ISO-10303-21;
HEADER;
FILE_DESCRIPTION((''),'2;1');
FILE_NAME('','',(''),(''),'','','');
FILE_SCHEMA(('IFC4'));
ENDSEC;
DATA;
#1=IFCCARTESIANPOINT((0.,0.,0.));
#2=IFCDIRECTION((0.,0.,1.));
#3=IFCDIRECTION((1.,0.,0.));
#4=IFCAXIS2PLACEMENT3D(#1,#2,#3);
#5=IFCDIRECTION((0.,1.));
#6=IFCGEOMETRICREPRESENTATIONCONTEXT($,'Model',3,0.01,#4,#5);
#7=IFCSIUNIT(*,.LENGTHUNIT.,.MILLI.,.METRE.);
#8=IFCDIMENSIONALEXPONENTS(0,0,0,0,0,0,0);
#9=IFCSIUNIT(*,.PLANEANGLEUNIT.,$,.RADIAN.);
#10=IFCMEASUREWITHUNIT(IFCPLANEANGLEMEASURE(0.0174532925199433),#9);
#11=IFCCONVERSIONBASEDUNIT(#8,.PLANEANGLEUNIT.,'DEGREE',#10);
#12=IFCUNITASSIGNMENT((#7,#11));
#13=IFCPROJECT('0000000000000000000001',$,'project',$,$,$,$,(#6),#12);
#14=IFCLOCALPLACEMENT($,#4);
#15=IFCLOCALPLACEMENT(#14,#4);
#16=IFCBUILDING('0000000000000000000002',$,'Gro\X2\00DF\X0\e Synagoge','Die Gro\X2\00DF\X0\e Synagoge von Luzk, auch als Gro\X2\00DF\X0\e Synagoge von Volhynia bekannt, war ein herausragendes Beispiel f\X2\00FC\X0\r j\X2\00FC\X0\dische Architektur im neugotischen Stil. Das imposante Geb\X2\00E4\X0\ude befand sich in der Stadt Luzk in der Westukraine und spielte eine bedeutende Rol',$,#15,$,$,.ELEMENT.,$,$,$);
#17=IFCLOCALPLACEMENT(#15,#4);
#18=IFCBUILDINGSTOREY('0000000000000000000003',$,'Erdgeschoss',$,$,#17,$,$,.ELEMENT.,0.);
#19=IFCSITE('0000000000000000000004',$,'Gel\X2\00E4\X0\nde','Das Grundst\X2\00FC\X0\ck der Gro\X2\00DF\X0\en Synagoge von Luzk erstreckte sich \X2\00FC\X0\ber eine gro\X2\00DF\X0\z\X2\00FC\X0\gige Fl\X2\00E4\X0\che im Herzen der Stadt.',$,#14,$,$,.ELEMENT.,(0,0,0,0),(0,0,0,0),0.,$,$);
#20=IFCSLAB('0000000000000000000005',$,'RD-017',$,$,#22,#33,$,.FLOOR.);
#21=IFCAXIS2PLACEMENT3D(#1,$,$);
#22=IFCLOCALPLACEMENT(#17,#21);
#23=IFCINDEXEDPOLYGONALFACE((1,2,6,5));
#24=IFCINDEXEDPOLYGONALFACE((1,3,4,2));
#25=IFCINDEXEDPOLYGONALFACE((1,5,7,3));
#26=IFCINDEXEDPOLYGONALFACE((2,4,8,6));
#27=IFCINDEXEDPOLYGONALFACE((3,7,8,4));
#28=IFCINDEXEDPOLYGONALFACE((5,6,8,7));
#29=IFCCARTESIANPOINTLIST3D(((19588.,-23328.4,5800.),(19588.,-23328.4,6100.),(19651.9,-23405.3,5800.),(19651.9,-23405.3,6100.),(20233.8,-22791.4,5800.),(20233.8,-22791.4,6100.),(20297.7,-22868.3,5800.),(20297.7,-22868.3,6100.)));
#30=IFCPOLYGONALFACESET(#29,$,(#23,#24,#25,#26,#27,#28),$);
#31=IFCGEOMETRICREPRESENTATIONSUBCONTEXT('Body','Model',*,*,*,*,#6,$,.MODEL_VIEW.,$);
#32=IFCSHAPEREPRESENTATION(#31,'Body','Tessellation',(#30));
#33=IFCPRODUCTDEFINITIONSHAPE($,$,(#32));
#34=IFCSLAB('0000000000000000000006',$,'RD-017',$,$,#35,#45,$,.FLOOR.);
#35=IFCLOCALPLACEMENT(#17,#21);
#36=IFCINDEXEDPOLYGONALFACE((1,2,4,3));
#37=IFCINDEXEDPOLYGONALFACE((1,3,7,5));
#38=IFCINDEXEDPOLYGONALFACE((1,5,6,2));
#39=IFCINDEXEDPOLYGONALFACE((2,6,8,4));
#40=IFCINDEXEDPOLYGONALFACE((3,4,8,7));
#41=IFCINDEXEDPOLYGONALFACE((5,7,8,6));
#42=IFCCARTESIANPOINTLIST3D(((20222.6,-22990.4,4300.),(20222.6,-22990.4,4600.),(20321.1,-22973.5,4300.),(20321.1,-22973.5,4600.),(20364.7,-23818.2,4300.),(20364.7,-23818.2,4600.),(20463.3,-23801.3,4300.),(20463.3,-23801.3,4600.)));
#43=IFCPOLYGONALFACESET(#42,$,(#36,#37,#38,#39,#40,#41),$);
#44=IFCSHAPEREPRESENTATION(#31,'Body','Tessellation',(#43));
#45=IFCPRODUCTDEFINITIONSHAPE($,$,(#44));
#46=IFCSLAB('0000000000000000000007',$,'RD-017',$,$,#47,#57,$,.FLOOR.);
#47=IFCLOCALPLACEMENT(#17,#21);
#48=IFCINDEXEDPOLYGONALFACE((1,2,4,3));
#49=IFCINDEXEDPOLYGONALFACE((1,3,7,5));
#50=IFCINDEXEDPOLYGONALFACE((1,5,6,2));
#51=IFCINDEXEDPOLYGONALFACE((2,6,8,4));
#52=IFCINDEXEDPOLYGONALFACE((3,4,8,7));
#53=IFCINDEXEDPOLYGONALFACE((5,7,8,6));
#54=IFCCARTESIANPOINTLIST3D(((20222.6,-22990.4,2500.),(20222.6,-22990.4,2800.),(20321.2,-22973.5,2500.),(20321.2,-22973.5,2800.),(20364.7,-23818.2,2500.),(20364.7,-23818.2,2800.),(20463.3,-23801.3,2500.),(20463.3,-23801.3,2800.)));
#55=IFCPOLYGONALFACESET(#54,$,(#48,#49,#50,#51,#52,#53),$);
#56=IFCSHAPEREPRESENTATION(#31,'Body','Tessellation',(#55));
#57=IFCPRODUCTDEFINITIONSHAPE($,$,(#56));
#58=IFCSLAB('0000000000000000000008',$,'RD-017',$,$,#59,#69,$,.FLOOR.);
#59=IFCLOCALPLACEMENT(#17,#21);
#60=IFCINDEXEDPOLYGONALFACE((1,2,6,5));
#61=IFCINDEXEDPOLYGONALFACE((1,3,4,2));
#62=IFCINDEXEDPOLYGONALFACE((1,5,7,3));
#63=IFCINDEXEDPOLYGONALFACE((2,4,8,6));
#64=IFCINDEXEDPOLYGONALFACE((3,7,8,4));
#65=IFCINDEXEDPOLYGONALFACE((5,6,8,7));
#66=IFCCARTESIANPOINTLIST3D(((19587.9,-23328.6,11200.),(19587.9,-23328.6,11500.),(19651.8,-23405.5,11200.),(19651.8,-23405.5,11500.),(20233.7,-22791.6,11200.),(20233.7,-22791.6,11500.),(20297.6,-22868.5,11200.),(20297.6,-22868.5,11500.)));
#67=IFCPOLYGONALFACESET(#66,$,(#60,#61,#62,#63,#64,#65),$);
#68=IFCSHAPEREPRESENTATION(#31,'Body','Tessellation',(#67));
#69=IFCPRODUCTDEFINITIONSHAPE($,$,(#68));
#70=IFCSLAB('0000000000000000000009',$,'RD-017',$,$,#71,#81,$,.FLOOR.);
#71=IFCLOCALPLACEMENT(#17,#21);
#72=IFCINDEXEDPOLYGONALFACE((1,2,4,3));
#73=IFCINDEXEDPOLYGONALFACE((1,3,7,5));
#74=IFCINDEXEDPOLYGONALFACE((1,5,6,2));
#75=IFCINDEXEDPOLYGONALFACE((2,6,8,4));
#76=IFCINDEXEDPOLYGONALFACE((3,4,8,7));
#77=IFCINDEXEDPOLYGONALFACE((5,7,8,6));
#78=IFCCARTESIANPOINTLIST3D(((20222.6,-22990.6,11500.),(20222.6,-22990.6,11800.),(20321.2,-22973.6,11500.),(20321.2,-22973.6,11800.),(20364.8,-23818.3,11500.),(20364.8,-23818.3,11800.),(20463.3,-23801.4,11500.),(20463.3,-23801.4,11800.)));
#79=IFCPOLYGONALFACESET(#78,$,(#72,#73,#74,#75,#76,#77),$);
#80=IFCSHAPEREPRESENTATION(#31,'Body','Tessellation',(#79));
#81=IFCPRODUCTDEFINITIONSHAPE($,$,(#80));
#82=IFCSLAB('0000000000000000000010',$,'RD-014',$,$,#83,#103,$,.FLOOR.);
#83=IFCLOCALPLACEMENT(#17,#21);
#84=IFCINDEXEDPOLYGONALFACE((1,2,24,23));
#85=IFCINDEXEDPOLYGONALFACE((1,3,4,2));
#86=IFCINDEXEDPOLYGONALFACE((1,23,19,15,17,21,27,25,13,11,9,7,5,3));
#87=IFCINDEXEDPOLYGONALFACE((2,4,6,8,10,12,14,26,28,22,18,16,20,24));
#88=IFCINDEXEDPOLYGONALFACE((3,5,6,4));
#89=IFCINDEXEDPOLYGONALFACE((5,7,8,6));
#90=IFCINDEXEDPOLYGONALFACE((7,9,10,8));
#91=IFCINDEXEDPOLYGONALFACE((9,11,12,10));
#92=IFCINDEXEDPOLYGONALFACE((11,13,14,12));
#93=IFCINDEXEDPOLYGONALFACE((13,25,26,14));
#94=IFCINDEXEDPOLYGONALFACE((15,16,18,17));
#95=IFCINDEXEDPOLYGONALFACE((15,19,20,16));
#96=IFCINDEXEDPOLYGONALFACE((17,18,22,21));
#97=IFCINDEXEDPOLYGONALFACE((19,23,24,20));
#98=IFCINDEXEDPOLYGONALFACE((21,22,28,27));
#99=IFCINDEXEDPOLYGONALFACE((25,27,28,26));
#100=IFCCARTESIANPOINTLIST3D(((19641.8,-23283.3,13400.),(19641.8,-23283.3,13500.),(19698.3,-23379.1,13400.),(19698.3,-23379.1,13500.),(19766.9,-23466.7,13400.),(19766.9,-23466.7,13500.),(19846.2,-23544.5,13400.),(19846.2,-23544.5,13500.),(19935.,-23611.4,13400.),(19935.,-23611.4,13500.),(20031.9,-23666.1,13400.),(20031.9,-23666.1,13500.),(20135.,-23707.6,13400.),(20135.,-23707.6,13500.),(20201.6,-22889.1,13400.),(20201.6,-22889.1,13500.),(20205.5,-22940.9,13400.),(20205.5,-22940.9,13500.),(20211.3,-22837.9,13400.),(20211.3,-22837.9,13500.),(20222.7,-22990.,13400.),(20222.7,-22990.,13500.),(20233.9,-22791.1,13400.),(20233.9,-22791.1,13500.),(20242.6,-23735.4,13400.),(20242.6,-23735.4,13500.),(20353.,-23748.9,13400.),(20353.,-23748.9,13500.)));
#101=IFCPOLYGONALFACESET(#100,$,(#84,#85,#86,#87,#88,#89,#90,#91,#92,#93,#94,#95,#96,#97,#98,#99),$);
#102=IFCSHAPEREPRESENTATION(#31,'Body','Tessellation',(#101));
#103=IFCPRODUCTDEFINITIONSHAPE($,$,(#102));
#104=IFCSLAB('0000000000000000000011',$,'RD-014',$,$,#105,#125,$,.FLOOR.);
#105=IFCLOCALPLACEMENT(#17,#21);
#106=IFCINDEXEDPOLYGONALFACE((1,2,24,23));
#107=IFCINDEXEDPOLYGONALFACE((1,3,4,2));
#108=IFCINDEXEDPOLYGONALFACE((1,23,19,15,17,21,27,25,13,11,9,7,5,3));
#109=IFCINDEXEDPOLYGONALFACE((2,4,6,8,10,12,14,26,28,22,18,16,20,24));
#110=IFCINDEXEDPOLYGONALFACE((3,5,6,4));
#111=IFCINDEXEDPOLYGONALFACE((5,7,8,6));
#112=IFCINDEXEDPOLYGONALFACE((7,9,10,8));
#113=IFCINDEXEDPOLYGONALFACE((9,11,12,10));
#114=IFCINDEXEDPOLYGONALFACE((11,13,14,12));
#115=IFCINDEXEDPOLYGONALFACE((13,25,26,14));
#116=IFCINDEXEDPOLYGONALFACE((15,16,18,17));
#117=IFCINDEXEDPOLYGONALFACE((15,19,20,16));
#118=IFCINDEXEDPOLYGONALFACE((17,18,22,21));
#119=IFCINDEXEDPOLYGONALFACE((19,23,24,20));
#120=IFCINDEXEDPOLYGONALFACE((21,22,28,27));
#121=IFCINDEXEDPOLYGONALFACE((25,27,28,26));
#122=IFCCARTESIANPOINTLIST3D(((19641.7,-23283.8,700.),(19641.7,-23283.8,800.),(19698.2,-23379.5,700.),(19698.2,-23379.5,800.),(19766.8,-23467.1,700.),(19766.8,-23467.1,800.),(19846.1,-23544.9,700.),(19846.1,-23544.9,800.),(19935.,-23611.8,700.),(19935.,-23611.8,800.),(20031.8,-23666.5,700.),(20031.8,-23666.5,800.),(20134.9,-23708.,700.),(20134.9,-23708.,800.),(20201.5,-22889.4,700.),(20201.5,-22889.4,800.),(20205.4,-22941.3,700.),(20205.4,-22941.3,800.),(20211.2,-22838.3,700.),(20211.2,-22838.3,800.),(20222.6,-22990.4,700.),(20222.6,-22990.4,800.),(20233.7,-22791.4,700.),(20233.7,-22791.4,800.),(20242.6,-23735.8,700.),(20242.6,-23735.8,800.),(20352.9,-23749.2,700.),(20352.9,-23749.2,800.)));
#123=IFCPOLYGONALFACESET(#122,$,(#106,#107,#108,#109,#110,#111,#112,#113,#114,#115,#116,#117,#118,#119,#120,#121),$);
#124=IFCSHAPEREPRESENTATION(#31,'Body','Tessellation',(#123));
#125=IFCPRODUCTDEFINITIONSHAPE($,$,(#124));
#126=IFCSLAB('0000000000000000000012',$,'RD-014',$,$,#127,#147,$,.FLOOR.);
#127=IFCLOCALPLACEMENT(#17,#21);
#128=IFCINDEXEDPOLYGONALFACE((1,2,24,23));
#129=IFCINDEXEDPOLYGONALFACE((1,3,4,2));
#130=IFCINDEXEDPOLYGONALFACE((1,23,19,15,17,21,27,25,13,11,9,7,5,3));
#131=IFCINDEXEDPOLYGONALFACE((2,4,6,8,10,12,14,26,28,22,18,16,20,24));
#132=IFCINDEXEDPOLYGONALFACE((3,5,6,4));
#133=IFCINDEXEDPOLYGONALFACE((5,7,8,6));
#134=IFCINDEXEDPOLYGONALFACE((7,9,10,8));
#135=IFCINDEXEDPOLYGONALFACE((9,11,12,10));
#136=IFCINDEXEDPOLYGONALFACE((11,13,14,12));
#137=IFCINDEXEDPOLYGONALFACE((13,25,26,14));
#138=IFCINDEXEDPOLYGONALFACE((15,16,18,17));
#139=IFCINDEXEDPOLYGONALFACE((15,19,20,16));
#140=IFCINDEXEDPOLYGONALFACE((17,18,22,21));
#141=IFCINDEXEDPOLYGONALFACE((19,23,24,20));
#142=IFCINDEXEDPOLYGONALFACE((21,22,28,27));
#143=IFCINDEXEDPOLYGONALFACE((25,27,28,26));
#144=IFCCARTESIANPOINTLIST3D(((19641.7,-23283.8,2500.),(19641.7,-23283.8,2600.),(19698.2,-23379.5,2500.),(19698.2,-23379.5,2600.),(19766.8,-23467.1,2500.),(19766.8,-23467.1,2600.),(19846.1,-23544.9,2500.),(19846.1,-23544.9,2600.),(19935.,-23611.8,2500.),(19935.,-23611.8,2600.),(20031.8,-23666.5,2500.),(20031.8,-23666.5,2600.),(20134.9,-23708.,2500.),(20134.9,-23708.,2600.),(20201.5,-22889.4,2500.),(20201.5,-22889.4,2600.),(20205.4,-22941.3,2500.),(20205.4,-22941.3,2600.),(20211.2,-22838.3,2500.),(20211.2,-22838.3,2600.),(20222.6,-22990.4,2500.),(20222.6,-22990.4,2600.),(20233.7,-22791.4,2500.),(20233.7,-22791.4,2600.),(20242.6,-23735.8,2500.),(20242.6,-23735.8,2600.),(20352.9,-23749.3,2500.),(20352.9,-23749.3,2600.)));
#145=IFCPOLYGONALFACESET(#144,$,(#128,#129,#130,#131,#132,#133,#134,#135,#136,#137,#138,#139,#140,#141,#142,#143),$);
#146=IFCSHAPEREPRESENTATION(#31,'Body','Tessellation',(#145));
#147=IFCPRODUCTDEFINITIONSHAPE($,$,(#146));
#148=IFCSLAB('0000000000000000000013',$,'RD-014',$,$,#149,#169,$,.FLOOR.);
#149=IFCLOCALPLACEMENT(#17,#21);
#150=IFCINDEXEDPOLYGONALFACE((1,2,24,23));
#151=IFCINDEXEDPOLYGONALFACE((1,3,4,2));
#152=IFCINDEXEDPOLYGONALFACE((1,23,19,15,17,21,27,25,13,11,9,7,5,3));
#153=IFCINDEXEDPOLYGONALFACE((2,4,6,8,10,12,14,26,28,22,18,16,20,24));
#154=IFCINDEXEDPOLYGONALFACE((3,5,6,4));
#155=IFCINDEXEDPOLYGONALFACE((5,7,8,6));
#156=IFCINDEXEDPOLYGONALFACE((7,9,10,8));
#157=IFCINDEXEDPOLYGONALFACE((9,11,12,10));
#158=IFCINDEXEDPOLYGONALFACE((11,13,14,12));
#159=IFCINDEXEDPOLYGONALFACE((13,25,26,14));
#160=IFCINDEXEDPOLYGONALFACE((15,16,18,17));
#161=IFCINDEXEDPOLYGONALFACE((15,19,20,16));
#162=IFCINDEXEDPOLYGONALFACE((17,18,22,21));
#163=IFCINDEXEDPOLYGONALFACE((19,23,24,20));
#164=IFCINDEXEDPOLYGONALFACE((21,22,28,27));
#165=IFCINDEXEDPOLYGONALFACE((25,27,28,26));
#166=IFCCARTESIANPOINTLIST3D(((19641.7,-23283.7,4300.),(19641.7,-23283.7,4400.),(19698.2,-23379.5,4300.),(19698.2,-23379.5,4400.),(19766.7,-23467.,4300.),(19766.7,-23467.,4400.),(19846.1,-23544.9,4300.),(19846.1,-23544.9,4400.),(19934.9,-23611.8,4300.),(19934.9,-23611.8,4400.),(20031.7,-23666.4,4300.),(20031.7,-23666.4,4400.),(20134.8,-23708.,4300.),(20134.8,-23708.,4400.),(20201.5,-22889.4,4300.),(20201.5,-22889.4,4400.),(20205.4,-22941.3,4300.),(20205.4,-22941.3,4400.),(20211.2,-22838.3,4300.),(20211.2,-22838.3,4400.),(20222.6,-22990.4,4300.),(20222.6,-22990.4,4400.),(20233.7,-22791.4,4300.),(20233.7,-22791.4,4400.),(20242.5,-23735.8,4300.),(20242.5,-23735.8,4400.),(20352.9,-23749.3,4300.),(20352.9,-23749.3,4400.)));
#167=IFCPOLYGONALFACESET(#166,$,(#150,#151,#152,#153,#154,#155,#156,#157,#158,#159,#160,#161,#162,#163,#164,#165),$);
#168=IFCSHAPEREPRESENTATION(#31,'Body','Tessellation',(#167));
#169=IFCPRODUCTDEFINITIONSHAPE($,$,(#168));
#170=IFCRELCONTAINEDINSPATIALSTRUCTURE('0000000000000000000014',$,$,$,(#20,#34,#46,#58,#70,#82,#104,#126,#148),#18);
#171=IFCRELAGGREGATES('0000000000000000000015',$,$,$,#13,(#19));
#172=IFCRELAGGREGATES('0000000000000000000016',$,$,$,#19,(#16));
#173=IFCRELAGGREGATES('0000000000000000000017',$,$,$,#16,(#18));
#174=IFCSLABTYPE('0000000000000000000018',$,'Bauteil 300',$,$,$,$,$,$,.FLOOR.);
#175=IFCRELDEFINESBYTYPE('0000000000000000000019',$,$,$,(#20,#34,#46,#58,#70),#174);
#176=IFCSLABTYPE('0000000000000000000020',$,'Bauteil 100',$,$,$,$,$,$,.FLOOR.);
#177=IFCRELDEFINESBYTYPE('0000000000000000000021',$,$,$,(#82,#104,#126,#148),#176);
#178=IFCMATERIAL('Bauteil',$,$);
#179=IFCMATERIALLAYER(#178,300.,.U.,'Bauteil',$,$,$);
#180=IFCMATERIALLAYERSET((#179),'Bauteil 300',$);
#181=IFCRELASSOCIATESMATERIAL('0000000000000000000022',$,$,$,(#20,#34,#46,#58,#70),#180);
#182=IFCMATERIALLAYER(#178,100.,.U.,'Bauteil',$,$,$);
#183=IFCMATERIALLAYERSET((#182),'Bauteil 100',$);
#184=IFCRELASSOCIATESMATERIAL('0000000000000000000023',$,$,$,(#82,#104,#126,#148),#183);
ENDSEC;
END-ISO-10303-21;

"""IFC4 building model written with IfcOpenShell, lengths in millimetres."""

from ifc_helpers import new_model, entity, si_unit, converted_unit, direction, frame, origin_with_axes, place, context, subcontext, project, spatial, line, arc, indexed_curve, outline, extrude, material, layer, layer_set, layer_usage, type_object, element, save


model = new_model("IFC4")

# Units and contexts
model_context = context("Model", 3, precision=0.01, world=origin_with_axes(), true_north=direction((0.0, 1.0)))
body_context = subcontext(model_context, "Body", "Model", "MODEL_VIEW")
ifc_project = project(units=[si_unit("LENGTHUNIT", "METRE", prefix="MILLI"), converted_unit("PLANEANGLEUNIT", "DEGREE", entity("IfcPlaneAngleMeasure", 0.0174532925199433), si_unit("PLANEANGLEUNIT", "RADIAN"), dimensions=[0, 0, 0, 0, 0, 0, 0])], contexts=[model_context])

# Site, building, storey
site_placement = place(None, origin_with_axes())
site = spatial("IfcSite", under=ifc_project, at=site_placement, Name="Gelände", Description="Das Grundstück der Großen Synagoge von Luzk erstreckte sich über eine großzügige Fläche im Herzen der Stadt.", CompositionType="ELEMENT", RefLatitude=(0, 0, 0, 0), RefLongitude=(0, 0, 0, 0), RefElevation=0.0)
building_placement = place(site_placement, origin_with_axes())
building = spatial("IfcBuilding", under=site, at=building_placement, Name="Große Synagoge", Description="Die Große Synagoge von Luzk, auch als Große Synagoge von Volhynia bekannt, war ein herausragendes Beispiel für jüdische Architektur im neugotischen Stil. Das imposante Gebäude befand sich in der Stadt Luzk in der Westukraine und spielte eine bedeutende Rol", CompositionType="ELEMENT")
storey_placement = place(building_placement, origin_with_axes())
storey = spatial("IfcBuildingStorey", under=building, at=storey_placement, Name="Erdgeschoss", CompositionType="ELEMENT", Elevation=0.0)

# Slabs
ifc_material_1 = material(Name="Bauteil")
ifc_layer_1 = layer(ifc_material_1, 300.0, ventilated="UNKNOWN", Name="Bauteil")
ifc_layer_set_1 = layer_set([ifc_layer_1], Name="Bauteil 300")
ifc_layer_usage_1 = layer_usage(ifc_layer_set_1, "AXIS3", "NEGATIVE", 300.0)
slab_type_1 = type_object("IfcSlabType", Name="Bauteil 300", PredefinedType="FLOOR")
slab_1_placement = place(storey_placement, frame((20297.7, -22868.3, 6100.0), z_axis=(0.0, 0.0, 1.0), x_axis=(1.0, 0.0, 0.0)))
element("IfcSlab", 1, at=slab_1_placement, inside=storey, type_object=slab_type_1, material=ifc_layer_usage_1, Name="RD-017", PredefinedType="FLOOR", context=body_context, shape_type="SweptSolid", body=[
    extrude(outline(indexed_curve([(0.0, 0.0), (-63.9, 76.9), (-709.7, -460.1), (-645.8, -537.0)], segments=[line(1, 2, 3, 4, 1)])), frame((0.0, 0.0, -300.0), z_axis=(0.0, 0.0, 1.0), x_axis=(1.0, 0.0, 0.0)), (0.0, 0.0, 1.0), 300.0),
])
ifc_layer_usage_2 = layer_usage(ifc_layer_set_1, "AXIS3", "NEGATIVE", 300.0)
slab_2_placement = place(storey_placement, frame((20321.1, -22973.5, 4600.0), z_axis=(0.0, 0.0, 1.0), x_axis=(1.0, 0.0, 0.0)))
element("IfcSlab", 2, at=slab_2_placement, inside=storey, type_object=slab_type_1, material=ifc_layer_usage_2, Name="RD-017", PredefinedType="FLOOR", context=body_context, shape_type="SweptSolid", body=[
    extrude(outline(indexed_curve([(0.0, 0.0), (-98.6, -16.9), (43.6, -844.7), (142.1, -827.8)], segments=[line(1, 2, 3, 4, 1)])), frame((0.0, 0.0, -300.0), z_axis=(0.0, 0.0, 1.0), x_axis=(1.0, 0.0, 0.0)), (0.0, 0.0, 1.0), 300.0),
])
ifc_layer_usage_3 = layer_usage(ifc_layer_set_1, "AXIS3", "NEGATIVE", 300.0)
slab_3_placement = place(storey_placement, frame((20321.2, -22973.5, 2800.0), z_axis=(0.0, 0.0, 1.0), x_axis=(1.0, 0.0, 0.0)))
element("IfcSlab", 3, at=slab_3_placement, inside=storey, type_object=slab_type_1, material=ifc_layer_usage_3, Name="RD-017", PredefinedType="FLOOR", context=body_context, shape_type="SweptSolid", body=[
    extrude(outline(indexed_curve([(0.0, 0.0), (-98.6, -16.9), (43.6, -844.7), (142.1, -827.8)], segments=[line(1, 2, 3, 4, 1)])), frame((0.0, 0.0, -300.0), z_axis=(0.0, 0.0, 1.0), x_axis=(1.0, 0.0, 0.0)), (0.0, 0.0, 1.0), 300.0),
])
ifc_layer_usage_4 = layer_usage(ifc_layer_set_1, "AXIS3", "NEGATIVE", 300.0)
slab_4_placement = place(storey_placement, frame((20297.6, -22868.5, 11500.0), z_axis=(0.0, 0.0, 1.0), x_axis=(1.0, 0.0, 0.0)))
element("IfcSlab", 4, at=slab_4_placement, inside=storey, type_object=slab_type_1, material=ifc_layer_usage_4, Name="RD-017", PredefinedType="FLOOR", context=body_context, shape_type="SweptSolid", body=[
    extrude(outline(indexed_curve([(0.0, 0.0), (-63.9, 76.9), (-709.7, -460.1), (-645.8, -537.0)], segments=[line(1, 2, 3, 4, 1)])), frame((0.0, 0.0, -300.0), z_axis=(0.0, 0.0, 1.0), x_axis=(1.0, 0.0, 0.0)), (0.0, 0.0, 1.0), 300.0),
])
ifc_layer_usage_5 = layer_usage(ifc_layer_set_1, "AXIS3", "NEGATIVE", 300.0)
slab_5_placement = place(storey_placement, frame((20321.2, -22973.6, 11800.0), z_axis=(0.0, 0.0, 1.0), x_axis=(1.0, 0.0, 0.0)))
element("IfcSlab", 5, at=slab_5_placement, inside=storey, type_object=slab_type_1, material=ifc_layer_usage_5, Name="RD-017", PredefinedType="FLOOR", context=body_context, shape_type="SweptSolid", body=[
    extrude(outline(indexed_curve([(0.0, 0.0), (-98.6, -16.9), (43.6, -844.7), (142.1, -827.8)], segments=[line(1, 2, 3, 4, 1)])), frame((0.0, 0.0, -300.0), z_axis=(0.0, 0.0, 1.0), x_axis=(1.0, 0.0, 0.0)), (0.0, 0.0, 1.0), 300.0),
])
ifc_layer_2 = layer(ifc_material_1, 100.0, ventilated="UNKNOWN", Name="Bauteil")
ifc_layer_set_2 = layer_set([ifc_layer_2], Name="Bauteil 100")
ifc_layer_usage_6 = layer_usage(ifc_layer_set_2, "AXIS3", "NEGATIVE", 100.0)
slab_type_2 = type_object("IfcSlabType", Name="Bauteil 100", PredefinedType="FLOOR")
slab_6_placement = place(storey_placement, frame((19641.8, -23283.3, 13500.0), z_axis=(0.0, 0.0, 1.0), x_axis=(1.0, 0.0, 0.0)))
element("IfcSlab", 6, at=slab_6_placement, inside=storey, type_object=slab_type_2, material=ifc_layer_usage_6, Name="RD-014", PredefinedType="FLOOR", context=body_context, shape_type="SweptSolid", body=[
    extrude(outline(indexed_curve([(0.0, 0.0), (293.2, -328.0), (711.2, -465.6), (580.9, 293.3), (559.8, 394.3), (592.0, 492.3)], segments=[arc(1, 2, 3), line(3, 4), arc(4, 5, 6), line(6, 1)])), frame((0.0, 0.0, -100.0), z_axis=(0.0, 0.0, 1.0), x_axis=(1.0, 0.0, 0.0)), (0.0, 0.0, 1.0), 100.0),
])
ifc_layer_usage_7 = layer_usage(ifc_layer_set_2, "AXIS3", "NEGATIVE", 100.0)
slab_7_placement = place(storey_placement, frame((19641.7, -23283.8, 800.0), z_axis=(0.0, 0.0, 1.0), x_axis=(1.0, 0.0, 0.0)))
element("IfcSlab", 7, at=slab_7_placement, inside=storey, type_object=slab_type_2, material=ifc_layer_usage_7, Name="RD-014", PredefinedType="FLOOR", context=body_context, shape_type="SweptSolid", body=[
    extrude(outline(indexed_curve([(0.0, 0.0), (293.2, -328.0), (711.2, -465.5), (580.8, 293.3), (559.8, 394.3), (592.0, 492.3)], segments=[arc(1, 2, 3), line(3, 4), arc(4, 5, 6), line(6, 1)])), frame((0.0, 0.0, -100.0), z_axis=(0.0, 0.0, 1.0), x_axis=(1.0, 0.0, 0.0)), (0.0, 0.0, 1.0), 100.0),
])
ifc_layer_usage_8 = layer_usage(ifc_layer_set_2, "AXIS3", "NEGATIVE", 100.0)
slab_8_placement = place(storey_placement, frame((19641.7, -23283.8, 2600.0), z_axis=(0.0, 0.0, 1.0), x_axis=(1.0, 0.0, 0.0)))
element("IfcSlab", 8, at=slab_8_placement, inside=storey, type_object=slab_type_2, material=ifc_layer_usage_8, Name="RD-014", PredefinedType="FLOOR", context=body_context, shape_type="SweptSolid", body=[
    extrude(outline(indexed_curve([(0.0, 0.0), (293.2, -328.0), (711.2, -465.5), (580.8, 293.3), (559.8, 394.3), (592.0, 492.3)], segments=[arc(1, 2, 3), line(3, 4), arc(4, 5, 6), line(6, 1)])), frame((0.0, 0.0, -100.0), z_axis=(0.0, 0.0, 1.0), x_axis=(1.0, 0.0, 0.0)), (0.0, 0.0, 1.0), 100.0),
])
ifc_layer_usage_9 = layer_usage(ifc_layer_set_2, "AXIS3", "NEGATIVE", 100.0)
slab_9_placement = place(storey_placement, frame((19641.7, -23283.7, 4400.0), z_axis=(0.0, 0.0, 1.0), x_axis=(1.0, 0.0, 0.0)))
element("IfcSlab", 9, at=slab_9_placement, inside=storey, type_object=slab_type_2, material=ifc_layer_usage_9, Name="RD-014", PredefinedType="FLOOR", context=body_context, shape_type="SweptSolid", body=[
    extrude(outline(indexed_curve([(0.0, 0.0), (293.2, -328.0), (711.2, -465.6), (580.9, 293.3), (559.8, 394.3), (592.0, 492.3)], segments=[arc(1, 2, 3), line(3, 4), arc(4, 5, 6), line(6, 1)])), frame((0.0, 0.0, -100.0), z_axis=(0.0, 0.0, 1.0), x_axis=(1.0, 0.0, 0.0)), (0.0, 0.0, 1.0), 100.0),
])

save(model, "model.ifc")
